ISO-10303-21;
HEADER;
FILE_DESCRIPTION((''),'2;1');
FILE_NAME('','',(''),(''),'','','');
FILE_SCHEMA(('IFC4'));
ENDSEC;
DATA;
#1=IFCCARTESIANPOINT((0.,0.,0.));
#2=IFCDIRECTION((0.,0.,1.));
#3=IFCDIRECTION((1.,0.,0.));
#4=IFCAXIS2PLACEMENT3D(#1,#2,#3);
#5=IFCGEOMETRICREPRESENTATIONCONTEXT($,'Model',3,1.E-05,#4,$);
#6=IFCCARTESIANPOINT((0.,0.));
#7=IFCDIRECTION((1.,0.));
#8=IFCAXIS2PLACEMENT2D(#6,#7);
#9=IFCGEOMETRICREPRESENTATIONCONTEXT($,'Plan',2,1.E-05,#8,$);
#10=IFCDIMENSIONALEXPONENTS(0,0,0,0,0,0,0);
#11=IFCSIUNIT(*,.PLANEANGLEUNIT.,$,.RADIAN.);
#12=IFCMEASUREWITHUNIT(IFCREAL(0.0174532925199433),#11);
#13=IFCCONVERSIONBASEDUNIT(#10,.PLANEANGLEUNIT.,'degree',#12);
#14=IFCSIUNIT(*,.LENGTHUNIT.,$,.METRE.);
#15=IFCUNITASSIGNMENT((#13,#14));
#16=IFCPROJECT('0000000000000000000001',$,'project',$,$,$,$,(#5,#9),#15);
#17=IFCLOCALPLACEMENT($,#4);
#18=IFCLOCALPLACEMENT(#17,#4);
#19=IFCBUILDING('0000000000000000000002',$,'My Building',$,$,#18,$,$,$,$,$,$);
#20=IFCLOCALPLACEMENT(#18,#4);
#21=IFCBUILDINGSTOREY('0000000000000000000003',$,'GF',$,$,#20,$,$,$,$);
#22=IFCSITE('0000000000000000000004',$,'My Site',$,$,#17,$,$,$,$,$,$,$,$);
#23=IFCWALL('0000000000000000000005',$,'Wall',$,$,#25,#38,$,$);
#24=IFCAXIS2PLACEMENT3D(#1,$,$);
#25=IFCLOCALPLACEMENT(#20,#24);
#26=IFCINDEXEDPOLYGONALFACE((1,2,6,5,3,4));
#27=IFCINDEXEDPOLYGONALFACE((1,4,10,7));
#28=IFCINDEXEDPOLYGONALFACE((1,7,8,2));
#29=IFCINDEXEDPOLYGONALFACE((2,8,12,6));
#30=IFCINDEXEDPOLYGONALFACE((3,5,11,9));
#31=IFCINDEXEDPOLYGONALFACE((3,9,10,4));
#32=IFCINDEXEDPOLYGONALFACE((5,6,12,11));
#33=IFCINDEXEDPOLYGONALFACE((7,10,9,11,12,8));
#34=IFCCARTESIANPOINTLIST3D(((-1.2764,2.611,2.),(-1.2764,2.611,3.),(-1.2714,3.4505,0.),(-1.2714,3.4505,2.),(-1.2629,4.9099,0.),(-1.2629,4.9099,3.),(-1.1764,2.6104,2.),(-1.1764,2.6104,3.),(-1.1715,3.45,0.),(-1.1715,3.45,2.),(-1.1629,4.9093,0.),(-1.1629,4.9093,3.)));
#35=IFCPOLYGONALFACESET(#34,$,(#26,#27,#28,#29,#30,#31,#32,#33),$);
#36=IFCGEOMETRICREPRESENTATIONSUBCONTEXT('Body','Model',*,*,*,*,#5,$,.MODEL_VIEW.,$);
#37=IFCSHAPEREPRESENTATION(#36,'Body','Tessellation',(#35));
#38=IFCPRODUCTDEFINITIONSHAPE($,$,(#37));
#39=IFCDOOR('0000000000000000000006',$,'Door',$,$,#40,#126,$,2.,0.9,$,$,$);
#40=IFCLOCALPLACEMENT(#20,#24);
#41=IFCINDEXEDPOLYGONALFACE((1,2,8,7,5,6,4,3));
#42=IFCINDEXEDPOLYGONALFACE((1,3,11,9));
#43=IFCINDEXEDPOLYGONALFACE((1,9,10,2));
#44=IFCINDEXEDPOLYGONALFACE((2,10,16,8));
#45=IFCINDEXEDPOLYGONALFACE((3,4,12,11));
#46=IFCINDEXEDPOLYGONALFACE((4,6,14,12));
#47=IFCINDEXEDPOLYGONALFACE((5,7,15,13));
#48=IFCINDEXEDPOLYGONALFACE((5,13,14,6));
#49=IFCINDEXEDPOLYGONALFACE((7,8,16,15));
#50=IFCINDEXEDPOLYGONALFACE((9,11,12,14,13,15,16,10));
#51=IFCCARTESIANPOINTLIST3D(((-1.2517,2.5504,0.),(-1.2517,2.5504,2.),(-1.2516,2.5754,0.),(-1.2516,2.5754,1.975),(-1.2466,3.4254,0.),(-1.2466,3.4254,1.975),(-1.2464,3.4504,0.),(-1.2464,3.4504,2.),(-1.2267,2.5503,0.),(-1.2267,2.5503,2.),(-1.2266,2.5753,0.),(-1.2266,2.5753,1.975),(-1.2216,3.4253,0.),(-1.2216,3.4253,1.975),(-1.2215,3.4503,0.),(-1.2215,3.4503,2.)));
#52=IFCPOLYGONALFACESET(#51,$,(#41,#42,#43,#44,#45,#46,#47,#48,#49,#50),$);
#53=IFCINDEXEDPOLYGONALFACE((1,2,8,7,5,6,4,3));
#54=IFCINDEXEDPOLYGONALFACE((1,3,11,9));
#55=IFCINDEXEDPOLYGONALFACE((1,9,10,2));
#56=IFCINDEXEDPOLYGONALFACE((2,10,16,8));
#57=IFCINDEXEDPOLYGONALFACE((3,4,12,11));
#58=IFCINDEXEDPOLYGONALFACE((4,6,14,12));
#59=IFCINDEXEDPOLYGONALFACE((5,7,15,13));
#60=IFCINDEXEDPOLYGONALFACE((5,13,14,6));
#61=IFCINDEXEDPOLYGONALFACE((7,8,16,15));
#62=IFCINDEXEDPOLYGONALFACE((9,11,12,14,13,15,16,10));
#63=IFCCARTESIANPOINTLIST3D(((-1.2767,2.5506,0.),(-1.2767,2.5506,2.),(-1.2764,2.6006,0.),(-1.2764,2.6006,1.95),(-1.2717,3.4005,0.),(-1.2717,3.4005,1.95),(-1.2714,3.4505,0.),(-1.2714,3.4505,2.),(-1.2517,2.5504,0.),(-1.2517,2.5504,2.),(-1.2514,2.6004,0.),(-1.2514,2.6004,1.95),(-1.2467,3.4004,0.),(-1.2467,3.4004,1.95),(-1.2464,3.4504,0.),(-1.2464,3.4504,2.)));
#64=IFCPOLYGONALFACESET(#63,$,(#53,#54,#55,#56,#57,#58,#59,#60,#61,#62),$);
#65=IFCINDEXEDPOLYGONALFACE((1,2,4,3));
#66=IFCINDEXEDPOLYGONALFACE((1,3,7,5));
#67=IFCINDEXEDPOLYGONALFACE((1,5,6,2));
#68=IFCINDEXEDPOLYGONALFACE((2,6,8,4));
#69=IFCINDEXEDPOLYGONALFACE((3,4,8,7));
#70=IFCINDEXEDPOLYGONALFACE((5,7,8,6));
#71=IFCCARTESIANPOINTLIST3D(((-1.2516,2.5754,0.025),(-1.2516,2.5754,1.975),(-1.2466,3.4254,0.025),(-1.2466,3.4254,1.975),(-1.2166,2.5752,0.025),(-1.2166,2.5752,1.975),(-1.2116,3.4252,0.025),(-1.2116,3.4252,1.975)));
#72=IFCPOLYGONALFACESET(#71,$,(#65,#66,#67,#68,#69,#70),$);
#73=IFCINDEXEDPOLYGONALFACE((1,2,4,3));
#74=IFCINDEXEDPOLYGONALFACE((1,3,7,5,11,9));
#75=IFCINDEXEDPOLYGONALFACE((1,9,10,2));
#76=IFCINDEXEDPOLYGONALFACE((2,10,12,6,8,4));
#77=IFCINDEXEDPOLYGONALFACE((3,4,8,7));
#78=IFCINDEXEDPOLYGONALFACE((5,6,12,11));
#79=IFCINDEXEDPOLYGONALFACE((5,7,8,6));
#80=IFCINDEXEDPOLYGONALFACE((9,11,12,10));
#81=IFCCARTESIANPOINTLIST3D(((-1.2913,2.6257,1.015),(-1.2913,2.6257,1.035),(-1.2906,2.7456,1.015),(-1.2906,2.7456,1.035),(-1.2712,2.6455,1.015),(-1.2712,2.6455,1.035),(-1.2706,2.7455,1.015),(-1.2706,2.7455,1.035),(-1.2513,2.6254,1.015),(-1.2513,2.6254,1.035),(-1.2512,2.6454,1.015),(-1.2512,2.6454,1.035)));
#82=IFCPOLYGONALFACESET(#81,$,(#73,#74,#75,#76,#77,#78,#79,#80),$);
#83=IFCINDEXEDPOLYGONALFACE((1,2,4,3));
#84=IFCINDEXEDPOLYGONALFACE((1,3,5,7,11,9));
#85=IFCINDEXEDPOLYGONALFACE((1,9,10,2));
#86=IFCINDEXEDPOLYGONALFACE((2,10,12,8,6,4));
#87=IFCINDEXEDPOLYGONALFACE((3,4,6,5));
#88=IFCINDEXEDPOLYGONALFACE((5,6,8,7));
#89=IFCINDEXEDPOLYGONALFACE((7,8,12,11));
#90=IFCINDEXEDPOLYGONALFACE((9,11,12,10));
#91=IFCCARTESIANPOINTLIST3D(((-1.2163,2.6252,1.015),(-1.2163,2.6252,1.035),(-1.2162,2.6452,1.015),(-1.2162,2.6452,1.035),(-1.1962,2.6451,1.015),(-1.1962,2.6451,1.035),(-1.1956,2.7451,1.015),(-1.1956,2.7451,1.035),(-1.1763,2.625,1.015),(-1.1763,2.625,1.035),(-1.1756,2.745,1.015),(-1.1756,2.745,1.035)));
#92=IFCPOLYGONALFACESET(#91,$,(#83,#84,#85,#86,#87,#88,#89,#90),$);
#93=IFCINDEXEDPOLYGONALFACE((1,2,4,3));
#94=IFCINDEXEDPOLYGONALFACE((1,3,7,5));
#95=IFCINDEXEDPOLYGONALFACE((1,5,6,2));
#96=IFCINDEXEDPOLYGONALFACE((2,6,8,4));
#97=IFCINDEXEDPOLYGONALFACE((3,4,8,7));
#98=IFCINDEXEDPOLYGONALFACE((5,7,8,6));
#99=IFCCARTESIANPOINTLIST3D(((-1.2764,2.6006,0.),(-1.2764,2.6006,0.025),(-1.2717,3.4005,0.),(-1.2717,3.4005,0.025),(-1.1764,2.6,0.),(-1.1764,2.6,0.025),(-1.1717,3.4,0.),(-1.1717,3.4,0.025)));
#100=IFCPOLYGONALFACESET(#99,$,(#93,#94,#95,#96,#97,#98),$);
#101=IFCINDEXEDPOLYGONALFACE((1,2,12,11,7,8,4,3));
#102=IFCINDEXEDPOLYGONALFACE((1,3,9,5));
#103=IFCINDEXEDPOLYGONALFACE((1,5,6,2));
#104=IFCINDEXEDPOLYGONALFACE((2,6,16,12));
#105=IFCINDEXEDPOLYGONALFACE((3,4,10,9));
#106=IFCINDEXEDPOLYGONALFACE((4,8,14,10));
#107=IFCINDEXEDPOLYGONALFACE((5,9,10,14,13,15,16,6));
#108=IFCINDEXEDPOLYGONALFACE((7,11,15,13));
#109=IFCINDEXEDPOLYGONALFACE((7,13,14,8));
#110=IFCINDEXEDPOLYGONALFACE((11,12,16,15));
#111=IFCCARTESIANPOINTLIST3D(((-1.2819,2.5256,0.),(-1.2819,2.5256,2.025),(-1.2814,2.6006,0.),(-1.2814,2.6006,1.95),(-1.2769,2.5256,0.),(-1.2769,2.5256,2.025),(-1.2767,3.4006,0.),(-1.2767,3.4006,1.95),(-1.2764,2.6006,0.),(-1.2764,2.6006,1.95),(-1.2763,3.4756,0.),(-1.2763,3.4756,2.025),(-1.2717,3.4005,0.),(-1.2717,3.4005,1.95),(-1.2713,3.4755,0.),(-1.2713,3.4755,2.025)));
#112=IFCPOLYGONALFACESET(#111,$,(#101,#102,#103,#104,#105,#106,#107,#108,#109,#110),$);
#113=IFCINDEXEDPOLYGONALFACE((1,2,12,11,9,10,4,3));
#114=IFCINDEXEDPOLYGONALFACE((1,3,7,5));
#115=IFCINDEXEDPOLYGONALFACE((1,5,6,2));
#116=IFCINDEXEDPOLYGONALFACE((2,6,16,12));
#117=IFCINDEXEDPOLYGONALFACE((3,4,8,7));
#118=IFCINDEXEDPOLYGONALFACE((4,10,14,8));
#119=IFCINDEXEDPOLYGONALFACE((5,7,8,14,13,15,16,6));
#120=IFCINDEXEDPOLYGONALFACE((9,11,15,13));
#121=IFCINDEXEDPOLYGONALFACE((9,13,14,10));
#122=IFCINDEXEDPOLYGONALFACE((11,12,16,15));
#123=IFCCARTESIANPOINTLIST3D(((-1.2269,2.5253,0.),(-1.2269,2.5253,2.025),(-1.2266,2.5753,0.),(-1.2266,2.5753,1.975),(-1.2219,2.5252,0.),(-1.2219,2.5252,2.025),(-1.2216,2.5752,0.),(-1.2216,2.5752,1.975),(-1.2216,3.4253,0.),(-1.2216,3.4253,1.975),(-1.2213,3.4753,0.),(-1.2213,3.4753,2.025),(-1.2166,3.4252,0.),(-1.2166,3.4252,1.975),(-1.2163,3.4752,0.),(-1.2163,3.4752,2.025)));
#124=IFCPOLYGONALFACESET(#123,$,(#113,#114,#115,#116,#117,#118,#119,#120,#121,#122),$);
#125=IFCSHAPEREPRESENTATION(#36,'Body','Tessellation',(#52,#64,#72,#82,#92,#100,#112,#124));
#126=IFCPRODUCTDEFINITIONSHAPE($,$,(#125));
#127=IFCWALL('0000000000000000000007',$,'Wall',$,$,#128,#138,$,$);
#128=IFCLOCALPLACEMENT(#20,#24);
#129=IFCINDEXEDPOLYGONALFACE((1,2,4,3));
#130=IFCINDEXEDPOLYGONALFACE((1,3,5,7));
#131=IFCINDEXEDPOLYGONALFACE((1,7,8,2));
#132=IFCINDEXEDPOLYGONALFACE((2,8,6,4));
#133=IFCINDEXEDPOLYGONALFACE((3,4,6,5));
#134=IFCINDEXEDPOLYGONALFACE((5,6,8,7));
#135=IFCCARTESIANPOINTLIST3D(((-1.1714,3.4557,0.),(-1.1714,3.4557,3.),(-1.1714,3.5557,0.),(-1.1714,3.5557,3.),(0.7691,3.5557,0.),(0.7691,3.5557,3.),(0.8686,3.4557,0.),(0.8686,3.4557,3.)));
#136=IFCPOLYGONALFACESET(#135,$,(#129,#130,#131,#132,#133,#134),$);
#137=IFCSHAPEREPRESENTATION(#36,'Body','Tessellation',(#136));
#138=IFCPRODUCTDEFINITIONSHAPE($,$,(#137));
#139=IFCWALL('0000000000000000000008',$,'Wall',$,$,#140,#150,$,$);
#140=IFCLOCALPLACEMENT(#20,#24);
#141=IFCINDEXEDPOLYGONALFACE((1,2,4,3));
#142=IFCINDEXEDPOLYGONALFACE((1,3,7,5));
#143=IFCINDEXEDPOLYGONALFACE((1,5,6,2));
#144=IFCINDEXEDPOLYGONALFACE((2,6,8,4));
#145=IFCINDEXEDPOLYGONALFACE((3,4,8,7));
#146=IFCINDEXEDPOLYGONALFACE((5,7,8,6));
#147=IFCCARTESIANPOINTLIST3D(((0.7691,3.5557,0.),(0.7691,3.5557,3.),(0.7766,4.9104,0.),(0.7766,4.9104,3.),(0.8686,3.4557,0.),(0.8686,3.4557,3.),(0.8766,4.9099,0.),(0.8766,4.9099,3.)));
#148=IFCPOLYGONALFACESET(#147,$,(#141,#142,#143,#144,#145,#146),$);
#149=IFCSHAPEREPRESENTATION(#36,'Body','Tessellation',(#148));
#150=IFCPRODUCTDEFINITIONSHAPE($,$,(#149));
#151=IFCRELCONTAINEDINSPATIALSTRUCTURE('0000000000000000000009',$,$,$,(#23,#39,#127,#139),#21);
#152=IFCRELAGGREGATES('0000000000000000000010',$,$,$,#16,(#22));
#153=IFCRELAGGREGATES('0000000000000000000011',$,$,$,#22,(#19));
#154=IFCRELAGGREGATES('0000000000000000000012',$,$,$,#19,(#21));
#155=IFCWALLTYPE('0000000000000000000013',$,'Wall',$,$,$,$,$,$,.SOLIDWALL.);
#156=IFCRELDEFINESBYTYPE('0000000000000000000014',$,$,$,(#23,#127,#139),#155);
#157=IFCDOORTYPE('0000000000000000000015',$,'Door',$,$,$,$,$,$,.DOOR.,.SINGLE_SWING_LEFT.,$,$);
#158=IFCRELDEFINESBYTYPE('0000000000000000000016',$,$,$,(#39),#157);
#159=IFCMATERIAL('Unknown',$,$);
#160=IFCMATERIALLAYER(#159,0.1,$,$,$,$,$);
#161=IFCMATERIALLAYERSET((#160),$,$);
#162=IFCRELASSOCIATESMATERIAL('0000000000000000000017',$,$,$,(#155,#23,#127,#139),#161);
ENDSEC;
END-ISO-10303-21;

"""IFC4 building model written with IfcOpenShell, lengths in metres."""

from ifc_helpers import new_model, entity, si_unit, converted_unit, frame, origin_with_axes, origin_2d_with_axis, place, context, subcontext, project, spatial, line, indexed_curve, outline, extrude, shape, source, transform, mapped, material, layer, layer_set, layer_usage, type_object, type_shapes, element, fill, save


model = new_model("IFC4")

# Units and contexts
model_context = context("Model", 3, precision=1e-05, world=origin_with_axes())
plan_context = context("Plan", 2, precision=1e-05, world=origin_2d_with_axis())
body_context_1 = subcontext(model_context, "Body", "Model", "MODEL_VIEW")
body_context_2 = subcontext(plan_context, "Body", "Plan", "PLAN_VIEW")
ifc_project = project(units=[converted_unit("PLANEANGLEUNIT", "degree", entity("IfcReal", 0.0174532925199433), si_unit("PLANEANGLEUNIT", "RADIAN"), dimensions=[0, 0, 0, 0, 0, 0, 0]), si_unit("LENGTHUNIT", "METRE")], contexts=[model_context, plan_context])

# Site, building, storey
site_placement = place(None, origin_with_axes())
site = spatial("IfcSite", under=ifc_project, at=site_placement, Name="My Site")
building_placement = place(site_placement, origin_with_axes())
building = spatial("IfcBuilding", under=site, at=building_placement, Name="My Building")
storey_placement = place(building_placement, origin_with_axes())
storey = spatial("IfcBuildingStorey", under=building, at=storey_placement, Name="GF")

# Shared definitions
ifc_material = material(Name="Unknown")

# Shared definitions
ifc_layer_1 = layer(ifc_material, 0.1)
ifc_layer_set_1 = layer_set([ifc_layer_1])
wall_type = type_object("IfcWallType", Name="Wall", PredefinedType="SOLIDWALL", material=ifc_layer_set_1)
shared_shape_1 = source(origin_with_axes(), body_context_1, "Body", "SweptSolid", [
    extrude(outline(indexed_curve([(0.0, 0.0), (0.9, 0.0), (0.9, 2.0), (0.0, 2.0)], segments=[line(1, 2, 3, 4, 1)])), frame((0.0, -0.6, 0.0), z_axis=(0.0, -1.0, 0.0), x_axis=(1.0, 0.0, 0.0)), (0.0, 0.0, -1.0), 1.2),
])
door_type = type_object("IfcDoorType", Name="Door", OperationType="SINGLE_SWING_LEFT", PredefinedType="DOOR")
shared_shape_2 = source(origin_with_axes(), body_context_1, "Body", "SweptSolid", [
    extrude(outline(indexed_curve([(0.0, 0.0), (0.0, 2.0), (0.9, 2.0), (0.9, 0.0), (0.875, 0.0), (0.875, 1.975), (0.025, 1.975), (0.025, 0.0)], segments=[line(1, 2, 3, 4, 5, 6, 7, 8, 1)])), frame((0.0, 0.025, 0.0), z_axis=(0.0, -1.0, 0.0), x_axis=(1.0, 0.0, 0.0)), (0.0, 0.0, -1.0), 0.025),
    extrude(outline(indexed_curve([(0.0, 0.0), (0.0, 2.0), (0.9, 2.0), (0.9, 0.0), (0.85, 0.0), (0.85, 1.95), (0.05, 1.95), (0.05, 0.0)], segments=[line(1, 2, 3, 4, 5, 6, 7, 8, 1)])), frame((0.0, 0.0, 0.0), z_axis=(0.0, -1.0, 0.0), x_axis=(1.0, 0.0, 0.0)), (0.0, 0.0, -1.0), 0.025),
    extrude(outline(indexed_curve([(0.0, 0.0), (0.85, 0.0), (0.85, 0.035), (0.0, 0.035)], segments=[line(1, 2, 3, 4, 1)])), frame((0.025, 0.025, 0.025), z_axis=(0.0, 0.0, 1.0), x_axis=(1.0, 0.0, 0.0)), (0.0, 0.0, 1.0), 1.95),
    extrude(outline(indexed_curve([(0.0, 0.0), (0.0, -0.04), (-0.12, -0.04), (-0.12, -0.02), (-0.02, -0.02), (-0.02, 0.0)], segments=[line(1, 2, 3, 4, 5, 6, 1)])), frame((0.825, 0.025, 1.015), z_axis=(0.0, 0.0, 1.0), x_axis=(1.0, 0.0, 0.0)), (0.0, 0.0, 1.0), 0.02),
    extrude(outline(indexed_curve([(0.0, 0.0), (0.0, 0.04), (-0.12, 0.04), (-0.12, 0.02), (-0.02, 0.02), (-0.02, 0.0)], segments=[line(1, 2, 3, 4, 5, 6, 1)])), frame((0.825, 0.06, 1.015), z_axis=(0.0, 0.0, 1.0), x_axis=(1.0, 0.0, 0.0)), (0.0, 0.0, 1.0), 0.02),
    extrude(outline(indexed_curve([(0.0, 0.0), (0.8, 0.0), (0.8, 0.1), (0.0, 0.1)], segments=[line(1, 2, 3, 4, 1)])), frame((0.05, 0.0, 0.0), z_axis=(0.0, 0.0, 1.0), x_axis=(1.0, 0.0, 0.0)), (0.0, 0.0, 1.0), 0.025),
    extrude(outline(indexed_curve([(0.0, 0.0), (0.0, 2.025), (0.95, 2.025), (0.95, 0.0), (0.875, 0.0), (0.875, 1.95), (0.075, 1.95), (0.075, 0.0)], segments=[line(1, 2, 3, 4, 5, 6, 7, 8, 1)])), frame((-0.025, -0.005, 0.0), z_axis=(0.0, -1.0, 0.0), x_axis=(1.0, 0.0, 0.0)), (0.0, 0.0, -1.0), 0.005),
    extrude(outline(indexed_curve([(0.0, 0.0), (0.0, 2.025), (0.95, 2.025), (0.95, 0.0), (0.9, 0.0), (0.9, 1.975), (0.05, 1.975), (0.05, 0.0)], segments=[line(1, 2, 3, 4, 5, 6, 7, 8, 1)])), frame((-0.025, 0.05, 0.0), z_axis=(0.0, -1.0, 0.0), x_axis=(1.0, 0.0, 0.0)), (0.0, 0.0, -1.0), 0.005),
])
shared_shape_3 = source(origin_with_axes(), body_context_2, "Body", "Curve2D", [
    entity("IfcIndexedPolyCurve", entity("IfcCartesianPointList2D", [[0.0, 0.0], [0.0, 0.05], [0.025, 0.05], [0.025, 0.025], [0.05, 0.025], [0.05, 0.0]]), [entity("IfcLineIndex", [1, 2, 3, 4, 5, 6, 1])]),
    entity("IfcIndexedPolyCurve", entity("IfcCartesianPointList2D", [[0.9, 0.0], [0.9, 0.05], [0.875, 0.05], [0.875, 0.025], [0.85, 0.025], [0.85, 0.0]]), [entity("IfcLineIndex", [1, 2, 3, 4, 5, 6, 1])]),
    entity("IfcTrimmedCurve", entity("IfcEllipse", entity("IfcAxis2Placement2D", entity("IfcCartesianPoint", [0.06, 0.05]), entity("IfcDirection", [1.0, 0.0])), 0.815, 0.85), [entity("IfcCartesianPoint", [0.875, 0.05])], [entity("IfcCartesianPoint", [0.06, 0.9])], True, "CARTESIAN"),
    entity("IfcIndexedPolyCurve", entity("IfcCartesianPointList2D", [[0.025, 0.05], [0.06, 0.05], [0.06, 0.9], [0.025, 0.9]]), [entity("IfcLineIndex", [1, 2, 3, 4, 1])]),
])
type_shapes(door_type, [shared_shape_2, shared_shape_3])

# Wall, opening, door
ifc_layer_usage_1 = layer_usage(ifc_layer_set_1, "AXIS2", "POSITIVE", 0.0)
wall_1_placement = place(storey_placement, frame((-1.2629, 4.9099, 0.0), z_axis=(0.0, 0.0, 1.0), x_axis=(-0.005858, -0.999983, 0.0)))
wall_1 = element("IfcWall", 1, at=wall_1_placement, inside=storey, type_object=wall_type, material=ifc_layer_usage_1, Name="Wall", context=body_context_1, shape_type="SweptSolid", body=[
    extrude(outline(indexed_curve([(0.0, 0.0), (0.0, 0.1), (2.299, 0.1), (2.299, 0.0)], segments=[line(1, 2, 3, 4, 1)])), origin_with_axes(), (0.0, 0.0, 1.0), 3.0),
])
opening_1_placement = place(wall_1_placement, frame((1.4594, 0.0, 0.0), z_axis=(0.0, 0.0, 1.0), x_axis=(1.0, 0.0, 0.0)))
opening_1 = element("IfcOpeningElement", 2, at=opening_1_placement, cuts=wall_1, PredefinedType="OPENING", context=body_context_1, shape_type="MappedRepresentation", body=[
    mapped(shared_shape_1, transform((0.0, 0.0, 0.0), x_axis=(1.0, 0.0, 0.0), y_axis=(0.0, 1.0, 0.0), z_axis=(0.0, 0.0, 1.0), scale=1.0)),
])
door_1_placement = place(opening_1_placement, frame((0.0, 0.0, 0.0), z_axis=(0.0, 0.0, 1.0), x_axis=(1.0, 0.0, 0.0)))
door_1 = element("IfcDoor", 3, at=door_1_placement, inside=storey, type_object=door_type, Name="Door", OverallHeight=2.0, OverallWidth=0.9, shapes=[
    shape(body_context_1, "Body", "MappedRepresentation", [mapped(shared_shape_2, transform((0.0, 0.0, 0.0), x_axis=(1.0, 0.0, 0.0), y_axis=(0.0, 1.0, 0.0), z_axis=(0.0, 0.0, 1.0), scale=1.0))]),
    shape(body_context_2, "Body", "MappedRepresentation", [mapped(shared_shape_3, transform((0.0, 0.0, 0.0), x_axis=(1.0, 0.0, 0.0), y_axis=(0.0, 1.0, 0.0), z_axis=(0.0, 0.0, 1.0), scale=1.0))]),
])
fill(opening_1, door_1)

# Walls
ifc_layer_usage_2 = layer_usage(ifc_layer_set_1, "AXIS2", "POSITIVE", 0.0)
wall_2_placement = place(storey_placement, frame((-1.1714, 3.4557, 0.0), z_axis=(0.0, 0.0, 1.0), x_axis=(1.0, 0.0, 0.0)))
element("IfcWall", 4, at=wall_2_placement, inside=storey, type_object=wall_type, material=ifc_layer_usage_2, Name="Wall", context=body_context_1, shape_type="SweptSolid", body=[
    extrude(outline(indexed_curve([(0.0, 0.0), (0.0, 0.1), (1.9406, 0.1), (2.04, 0.0)], segments=[line(1, 2, 3, 4, 1)])), origin_with_axes(), (0.0, 0.0, 1.0), 3.0),
])
ifc_layer_usage_3 = layer_usage(ifc_layer_set_1, "AXIS2", "POSITIVE", 0.0)
wall_3_placement = place(storey_placement, frame((0.8686, 3.4557, 0.0), z_axis=(0.0, 0.0, 1.0), x_axis=(0.005517, 0.999985, 0.0)))
element("IfcWall", 5, at=wall_3_placement, inside=storey, type_object=wall_type, material=ifc_layer_usage_3, Name="Wall", context=body_context_1, shape_type="SweptSolid", body=[
    extrude(outline(indexed_curve([(0.0, 0.0), (0.0994, 0.1), (1.4542, 0.1), (1.4542, 0.0)], segments=[line(1, 2, 3, 4, 1)])), origin_with_axes(), (0.0, 0.0, 1.0), 3.0),
])

save(model, "model.ifc")
